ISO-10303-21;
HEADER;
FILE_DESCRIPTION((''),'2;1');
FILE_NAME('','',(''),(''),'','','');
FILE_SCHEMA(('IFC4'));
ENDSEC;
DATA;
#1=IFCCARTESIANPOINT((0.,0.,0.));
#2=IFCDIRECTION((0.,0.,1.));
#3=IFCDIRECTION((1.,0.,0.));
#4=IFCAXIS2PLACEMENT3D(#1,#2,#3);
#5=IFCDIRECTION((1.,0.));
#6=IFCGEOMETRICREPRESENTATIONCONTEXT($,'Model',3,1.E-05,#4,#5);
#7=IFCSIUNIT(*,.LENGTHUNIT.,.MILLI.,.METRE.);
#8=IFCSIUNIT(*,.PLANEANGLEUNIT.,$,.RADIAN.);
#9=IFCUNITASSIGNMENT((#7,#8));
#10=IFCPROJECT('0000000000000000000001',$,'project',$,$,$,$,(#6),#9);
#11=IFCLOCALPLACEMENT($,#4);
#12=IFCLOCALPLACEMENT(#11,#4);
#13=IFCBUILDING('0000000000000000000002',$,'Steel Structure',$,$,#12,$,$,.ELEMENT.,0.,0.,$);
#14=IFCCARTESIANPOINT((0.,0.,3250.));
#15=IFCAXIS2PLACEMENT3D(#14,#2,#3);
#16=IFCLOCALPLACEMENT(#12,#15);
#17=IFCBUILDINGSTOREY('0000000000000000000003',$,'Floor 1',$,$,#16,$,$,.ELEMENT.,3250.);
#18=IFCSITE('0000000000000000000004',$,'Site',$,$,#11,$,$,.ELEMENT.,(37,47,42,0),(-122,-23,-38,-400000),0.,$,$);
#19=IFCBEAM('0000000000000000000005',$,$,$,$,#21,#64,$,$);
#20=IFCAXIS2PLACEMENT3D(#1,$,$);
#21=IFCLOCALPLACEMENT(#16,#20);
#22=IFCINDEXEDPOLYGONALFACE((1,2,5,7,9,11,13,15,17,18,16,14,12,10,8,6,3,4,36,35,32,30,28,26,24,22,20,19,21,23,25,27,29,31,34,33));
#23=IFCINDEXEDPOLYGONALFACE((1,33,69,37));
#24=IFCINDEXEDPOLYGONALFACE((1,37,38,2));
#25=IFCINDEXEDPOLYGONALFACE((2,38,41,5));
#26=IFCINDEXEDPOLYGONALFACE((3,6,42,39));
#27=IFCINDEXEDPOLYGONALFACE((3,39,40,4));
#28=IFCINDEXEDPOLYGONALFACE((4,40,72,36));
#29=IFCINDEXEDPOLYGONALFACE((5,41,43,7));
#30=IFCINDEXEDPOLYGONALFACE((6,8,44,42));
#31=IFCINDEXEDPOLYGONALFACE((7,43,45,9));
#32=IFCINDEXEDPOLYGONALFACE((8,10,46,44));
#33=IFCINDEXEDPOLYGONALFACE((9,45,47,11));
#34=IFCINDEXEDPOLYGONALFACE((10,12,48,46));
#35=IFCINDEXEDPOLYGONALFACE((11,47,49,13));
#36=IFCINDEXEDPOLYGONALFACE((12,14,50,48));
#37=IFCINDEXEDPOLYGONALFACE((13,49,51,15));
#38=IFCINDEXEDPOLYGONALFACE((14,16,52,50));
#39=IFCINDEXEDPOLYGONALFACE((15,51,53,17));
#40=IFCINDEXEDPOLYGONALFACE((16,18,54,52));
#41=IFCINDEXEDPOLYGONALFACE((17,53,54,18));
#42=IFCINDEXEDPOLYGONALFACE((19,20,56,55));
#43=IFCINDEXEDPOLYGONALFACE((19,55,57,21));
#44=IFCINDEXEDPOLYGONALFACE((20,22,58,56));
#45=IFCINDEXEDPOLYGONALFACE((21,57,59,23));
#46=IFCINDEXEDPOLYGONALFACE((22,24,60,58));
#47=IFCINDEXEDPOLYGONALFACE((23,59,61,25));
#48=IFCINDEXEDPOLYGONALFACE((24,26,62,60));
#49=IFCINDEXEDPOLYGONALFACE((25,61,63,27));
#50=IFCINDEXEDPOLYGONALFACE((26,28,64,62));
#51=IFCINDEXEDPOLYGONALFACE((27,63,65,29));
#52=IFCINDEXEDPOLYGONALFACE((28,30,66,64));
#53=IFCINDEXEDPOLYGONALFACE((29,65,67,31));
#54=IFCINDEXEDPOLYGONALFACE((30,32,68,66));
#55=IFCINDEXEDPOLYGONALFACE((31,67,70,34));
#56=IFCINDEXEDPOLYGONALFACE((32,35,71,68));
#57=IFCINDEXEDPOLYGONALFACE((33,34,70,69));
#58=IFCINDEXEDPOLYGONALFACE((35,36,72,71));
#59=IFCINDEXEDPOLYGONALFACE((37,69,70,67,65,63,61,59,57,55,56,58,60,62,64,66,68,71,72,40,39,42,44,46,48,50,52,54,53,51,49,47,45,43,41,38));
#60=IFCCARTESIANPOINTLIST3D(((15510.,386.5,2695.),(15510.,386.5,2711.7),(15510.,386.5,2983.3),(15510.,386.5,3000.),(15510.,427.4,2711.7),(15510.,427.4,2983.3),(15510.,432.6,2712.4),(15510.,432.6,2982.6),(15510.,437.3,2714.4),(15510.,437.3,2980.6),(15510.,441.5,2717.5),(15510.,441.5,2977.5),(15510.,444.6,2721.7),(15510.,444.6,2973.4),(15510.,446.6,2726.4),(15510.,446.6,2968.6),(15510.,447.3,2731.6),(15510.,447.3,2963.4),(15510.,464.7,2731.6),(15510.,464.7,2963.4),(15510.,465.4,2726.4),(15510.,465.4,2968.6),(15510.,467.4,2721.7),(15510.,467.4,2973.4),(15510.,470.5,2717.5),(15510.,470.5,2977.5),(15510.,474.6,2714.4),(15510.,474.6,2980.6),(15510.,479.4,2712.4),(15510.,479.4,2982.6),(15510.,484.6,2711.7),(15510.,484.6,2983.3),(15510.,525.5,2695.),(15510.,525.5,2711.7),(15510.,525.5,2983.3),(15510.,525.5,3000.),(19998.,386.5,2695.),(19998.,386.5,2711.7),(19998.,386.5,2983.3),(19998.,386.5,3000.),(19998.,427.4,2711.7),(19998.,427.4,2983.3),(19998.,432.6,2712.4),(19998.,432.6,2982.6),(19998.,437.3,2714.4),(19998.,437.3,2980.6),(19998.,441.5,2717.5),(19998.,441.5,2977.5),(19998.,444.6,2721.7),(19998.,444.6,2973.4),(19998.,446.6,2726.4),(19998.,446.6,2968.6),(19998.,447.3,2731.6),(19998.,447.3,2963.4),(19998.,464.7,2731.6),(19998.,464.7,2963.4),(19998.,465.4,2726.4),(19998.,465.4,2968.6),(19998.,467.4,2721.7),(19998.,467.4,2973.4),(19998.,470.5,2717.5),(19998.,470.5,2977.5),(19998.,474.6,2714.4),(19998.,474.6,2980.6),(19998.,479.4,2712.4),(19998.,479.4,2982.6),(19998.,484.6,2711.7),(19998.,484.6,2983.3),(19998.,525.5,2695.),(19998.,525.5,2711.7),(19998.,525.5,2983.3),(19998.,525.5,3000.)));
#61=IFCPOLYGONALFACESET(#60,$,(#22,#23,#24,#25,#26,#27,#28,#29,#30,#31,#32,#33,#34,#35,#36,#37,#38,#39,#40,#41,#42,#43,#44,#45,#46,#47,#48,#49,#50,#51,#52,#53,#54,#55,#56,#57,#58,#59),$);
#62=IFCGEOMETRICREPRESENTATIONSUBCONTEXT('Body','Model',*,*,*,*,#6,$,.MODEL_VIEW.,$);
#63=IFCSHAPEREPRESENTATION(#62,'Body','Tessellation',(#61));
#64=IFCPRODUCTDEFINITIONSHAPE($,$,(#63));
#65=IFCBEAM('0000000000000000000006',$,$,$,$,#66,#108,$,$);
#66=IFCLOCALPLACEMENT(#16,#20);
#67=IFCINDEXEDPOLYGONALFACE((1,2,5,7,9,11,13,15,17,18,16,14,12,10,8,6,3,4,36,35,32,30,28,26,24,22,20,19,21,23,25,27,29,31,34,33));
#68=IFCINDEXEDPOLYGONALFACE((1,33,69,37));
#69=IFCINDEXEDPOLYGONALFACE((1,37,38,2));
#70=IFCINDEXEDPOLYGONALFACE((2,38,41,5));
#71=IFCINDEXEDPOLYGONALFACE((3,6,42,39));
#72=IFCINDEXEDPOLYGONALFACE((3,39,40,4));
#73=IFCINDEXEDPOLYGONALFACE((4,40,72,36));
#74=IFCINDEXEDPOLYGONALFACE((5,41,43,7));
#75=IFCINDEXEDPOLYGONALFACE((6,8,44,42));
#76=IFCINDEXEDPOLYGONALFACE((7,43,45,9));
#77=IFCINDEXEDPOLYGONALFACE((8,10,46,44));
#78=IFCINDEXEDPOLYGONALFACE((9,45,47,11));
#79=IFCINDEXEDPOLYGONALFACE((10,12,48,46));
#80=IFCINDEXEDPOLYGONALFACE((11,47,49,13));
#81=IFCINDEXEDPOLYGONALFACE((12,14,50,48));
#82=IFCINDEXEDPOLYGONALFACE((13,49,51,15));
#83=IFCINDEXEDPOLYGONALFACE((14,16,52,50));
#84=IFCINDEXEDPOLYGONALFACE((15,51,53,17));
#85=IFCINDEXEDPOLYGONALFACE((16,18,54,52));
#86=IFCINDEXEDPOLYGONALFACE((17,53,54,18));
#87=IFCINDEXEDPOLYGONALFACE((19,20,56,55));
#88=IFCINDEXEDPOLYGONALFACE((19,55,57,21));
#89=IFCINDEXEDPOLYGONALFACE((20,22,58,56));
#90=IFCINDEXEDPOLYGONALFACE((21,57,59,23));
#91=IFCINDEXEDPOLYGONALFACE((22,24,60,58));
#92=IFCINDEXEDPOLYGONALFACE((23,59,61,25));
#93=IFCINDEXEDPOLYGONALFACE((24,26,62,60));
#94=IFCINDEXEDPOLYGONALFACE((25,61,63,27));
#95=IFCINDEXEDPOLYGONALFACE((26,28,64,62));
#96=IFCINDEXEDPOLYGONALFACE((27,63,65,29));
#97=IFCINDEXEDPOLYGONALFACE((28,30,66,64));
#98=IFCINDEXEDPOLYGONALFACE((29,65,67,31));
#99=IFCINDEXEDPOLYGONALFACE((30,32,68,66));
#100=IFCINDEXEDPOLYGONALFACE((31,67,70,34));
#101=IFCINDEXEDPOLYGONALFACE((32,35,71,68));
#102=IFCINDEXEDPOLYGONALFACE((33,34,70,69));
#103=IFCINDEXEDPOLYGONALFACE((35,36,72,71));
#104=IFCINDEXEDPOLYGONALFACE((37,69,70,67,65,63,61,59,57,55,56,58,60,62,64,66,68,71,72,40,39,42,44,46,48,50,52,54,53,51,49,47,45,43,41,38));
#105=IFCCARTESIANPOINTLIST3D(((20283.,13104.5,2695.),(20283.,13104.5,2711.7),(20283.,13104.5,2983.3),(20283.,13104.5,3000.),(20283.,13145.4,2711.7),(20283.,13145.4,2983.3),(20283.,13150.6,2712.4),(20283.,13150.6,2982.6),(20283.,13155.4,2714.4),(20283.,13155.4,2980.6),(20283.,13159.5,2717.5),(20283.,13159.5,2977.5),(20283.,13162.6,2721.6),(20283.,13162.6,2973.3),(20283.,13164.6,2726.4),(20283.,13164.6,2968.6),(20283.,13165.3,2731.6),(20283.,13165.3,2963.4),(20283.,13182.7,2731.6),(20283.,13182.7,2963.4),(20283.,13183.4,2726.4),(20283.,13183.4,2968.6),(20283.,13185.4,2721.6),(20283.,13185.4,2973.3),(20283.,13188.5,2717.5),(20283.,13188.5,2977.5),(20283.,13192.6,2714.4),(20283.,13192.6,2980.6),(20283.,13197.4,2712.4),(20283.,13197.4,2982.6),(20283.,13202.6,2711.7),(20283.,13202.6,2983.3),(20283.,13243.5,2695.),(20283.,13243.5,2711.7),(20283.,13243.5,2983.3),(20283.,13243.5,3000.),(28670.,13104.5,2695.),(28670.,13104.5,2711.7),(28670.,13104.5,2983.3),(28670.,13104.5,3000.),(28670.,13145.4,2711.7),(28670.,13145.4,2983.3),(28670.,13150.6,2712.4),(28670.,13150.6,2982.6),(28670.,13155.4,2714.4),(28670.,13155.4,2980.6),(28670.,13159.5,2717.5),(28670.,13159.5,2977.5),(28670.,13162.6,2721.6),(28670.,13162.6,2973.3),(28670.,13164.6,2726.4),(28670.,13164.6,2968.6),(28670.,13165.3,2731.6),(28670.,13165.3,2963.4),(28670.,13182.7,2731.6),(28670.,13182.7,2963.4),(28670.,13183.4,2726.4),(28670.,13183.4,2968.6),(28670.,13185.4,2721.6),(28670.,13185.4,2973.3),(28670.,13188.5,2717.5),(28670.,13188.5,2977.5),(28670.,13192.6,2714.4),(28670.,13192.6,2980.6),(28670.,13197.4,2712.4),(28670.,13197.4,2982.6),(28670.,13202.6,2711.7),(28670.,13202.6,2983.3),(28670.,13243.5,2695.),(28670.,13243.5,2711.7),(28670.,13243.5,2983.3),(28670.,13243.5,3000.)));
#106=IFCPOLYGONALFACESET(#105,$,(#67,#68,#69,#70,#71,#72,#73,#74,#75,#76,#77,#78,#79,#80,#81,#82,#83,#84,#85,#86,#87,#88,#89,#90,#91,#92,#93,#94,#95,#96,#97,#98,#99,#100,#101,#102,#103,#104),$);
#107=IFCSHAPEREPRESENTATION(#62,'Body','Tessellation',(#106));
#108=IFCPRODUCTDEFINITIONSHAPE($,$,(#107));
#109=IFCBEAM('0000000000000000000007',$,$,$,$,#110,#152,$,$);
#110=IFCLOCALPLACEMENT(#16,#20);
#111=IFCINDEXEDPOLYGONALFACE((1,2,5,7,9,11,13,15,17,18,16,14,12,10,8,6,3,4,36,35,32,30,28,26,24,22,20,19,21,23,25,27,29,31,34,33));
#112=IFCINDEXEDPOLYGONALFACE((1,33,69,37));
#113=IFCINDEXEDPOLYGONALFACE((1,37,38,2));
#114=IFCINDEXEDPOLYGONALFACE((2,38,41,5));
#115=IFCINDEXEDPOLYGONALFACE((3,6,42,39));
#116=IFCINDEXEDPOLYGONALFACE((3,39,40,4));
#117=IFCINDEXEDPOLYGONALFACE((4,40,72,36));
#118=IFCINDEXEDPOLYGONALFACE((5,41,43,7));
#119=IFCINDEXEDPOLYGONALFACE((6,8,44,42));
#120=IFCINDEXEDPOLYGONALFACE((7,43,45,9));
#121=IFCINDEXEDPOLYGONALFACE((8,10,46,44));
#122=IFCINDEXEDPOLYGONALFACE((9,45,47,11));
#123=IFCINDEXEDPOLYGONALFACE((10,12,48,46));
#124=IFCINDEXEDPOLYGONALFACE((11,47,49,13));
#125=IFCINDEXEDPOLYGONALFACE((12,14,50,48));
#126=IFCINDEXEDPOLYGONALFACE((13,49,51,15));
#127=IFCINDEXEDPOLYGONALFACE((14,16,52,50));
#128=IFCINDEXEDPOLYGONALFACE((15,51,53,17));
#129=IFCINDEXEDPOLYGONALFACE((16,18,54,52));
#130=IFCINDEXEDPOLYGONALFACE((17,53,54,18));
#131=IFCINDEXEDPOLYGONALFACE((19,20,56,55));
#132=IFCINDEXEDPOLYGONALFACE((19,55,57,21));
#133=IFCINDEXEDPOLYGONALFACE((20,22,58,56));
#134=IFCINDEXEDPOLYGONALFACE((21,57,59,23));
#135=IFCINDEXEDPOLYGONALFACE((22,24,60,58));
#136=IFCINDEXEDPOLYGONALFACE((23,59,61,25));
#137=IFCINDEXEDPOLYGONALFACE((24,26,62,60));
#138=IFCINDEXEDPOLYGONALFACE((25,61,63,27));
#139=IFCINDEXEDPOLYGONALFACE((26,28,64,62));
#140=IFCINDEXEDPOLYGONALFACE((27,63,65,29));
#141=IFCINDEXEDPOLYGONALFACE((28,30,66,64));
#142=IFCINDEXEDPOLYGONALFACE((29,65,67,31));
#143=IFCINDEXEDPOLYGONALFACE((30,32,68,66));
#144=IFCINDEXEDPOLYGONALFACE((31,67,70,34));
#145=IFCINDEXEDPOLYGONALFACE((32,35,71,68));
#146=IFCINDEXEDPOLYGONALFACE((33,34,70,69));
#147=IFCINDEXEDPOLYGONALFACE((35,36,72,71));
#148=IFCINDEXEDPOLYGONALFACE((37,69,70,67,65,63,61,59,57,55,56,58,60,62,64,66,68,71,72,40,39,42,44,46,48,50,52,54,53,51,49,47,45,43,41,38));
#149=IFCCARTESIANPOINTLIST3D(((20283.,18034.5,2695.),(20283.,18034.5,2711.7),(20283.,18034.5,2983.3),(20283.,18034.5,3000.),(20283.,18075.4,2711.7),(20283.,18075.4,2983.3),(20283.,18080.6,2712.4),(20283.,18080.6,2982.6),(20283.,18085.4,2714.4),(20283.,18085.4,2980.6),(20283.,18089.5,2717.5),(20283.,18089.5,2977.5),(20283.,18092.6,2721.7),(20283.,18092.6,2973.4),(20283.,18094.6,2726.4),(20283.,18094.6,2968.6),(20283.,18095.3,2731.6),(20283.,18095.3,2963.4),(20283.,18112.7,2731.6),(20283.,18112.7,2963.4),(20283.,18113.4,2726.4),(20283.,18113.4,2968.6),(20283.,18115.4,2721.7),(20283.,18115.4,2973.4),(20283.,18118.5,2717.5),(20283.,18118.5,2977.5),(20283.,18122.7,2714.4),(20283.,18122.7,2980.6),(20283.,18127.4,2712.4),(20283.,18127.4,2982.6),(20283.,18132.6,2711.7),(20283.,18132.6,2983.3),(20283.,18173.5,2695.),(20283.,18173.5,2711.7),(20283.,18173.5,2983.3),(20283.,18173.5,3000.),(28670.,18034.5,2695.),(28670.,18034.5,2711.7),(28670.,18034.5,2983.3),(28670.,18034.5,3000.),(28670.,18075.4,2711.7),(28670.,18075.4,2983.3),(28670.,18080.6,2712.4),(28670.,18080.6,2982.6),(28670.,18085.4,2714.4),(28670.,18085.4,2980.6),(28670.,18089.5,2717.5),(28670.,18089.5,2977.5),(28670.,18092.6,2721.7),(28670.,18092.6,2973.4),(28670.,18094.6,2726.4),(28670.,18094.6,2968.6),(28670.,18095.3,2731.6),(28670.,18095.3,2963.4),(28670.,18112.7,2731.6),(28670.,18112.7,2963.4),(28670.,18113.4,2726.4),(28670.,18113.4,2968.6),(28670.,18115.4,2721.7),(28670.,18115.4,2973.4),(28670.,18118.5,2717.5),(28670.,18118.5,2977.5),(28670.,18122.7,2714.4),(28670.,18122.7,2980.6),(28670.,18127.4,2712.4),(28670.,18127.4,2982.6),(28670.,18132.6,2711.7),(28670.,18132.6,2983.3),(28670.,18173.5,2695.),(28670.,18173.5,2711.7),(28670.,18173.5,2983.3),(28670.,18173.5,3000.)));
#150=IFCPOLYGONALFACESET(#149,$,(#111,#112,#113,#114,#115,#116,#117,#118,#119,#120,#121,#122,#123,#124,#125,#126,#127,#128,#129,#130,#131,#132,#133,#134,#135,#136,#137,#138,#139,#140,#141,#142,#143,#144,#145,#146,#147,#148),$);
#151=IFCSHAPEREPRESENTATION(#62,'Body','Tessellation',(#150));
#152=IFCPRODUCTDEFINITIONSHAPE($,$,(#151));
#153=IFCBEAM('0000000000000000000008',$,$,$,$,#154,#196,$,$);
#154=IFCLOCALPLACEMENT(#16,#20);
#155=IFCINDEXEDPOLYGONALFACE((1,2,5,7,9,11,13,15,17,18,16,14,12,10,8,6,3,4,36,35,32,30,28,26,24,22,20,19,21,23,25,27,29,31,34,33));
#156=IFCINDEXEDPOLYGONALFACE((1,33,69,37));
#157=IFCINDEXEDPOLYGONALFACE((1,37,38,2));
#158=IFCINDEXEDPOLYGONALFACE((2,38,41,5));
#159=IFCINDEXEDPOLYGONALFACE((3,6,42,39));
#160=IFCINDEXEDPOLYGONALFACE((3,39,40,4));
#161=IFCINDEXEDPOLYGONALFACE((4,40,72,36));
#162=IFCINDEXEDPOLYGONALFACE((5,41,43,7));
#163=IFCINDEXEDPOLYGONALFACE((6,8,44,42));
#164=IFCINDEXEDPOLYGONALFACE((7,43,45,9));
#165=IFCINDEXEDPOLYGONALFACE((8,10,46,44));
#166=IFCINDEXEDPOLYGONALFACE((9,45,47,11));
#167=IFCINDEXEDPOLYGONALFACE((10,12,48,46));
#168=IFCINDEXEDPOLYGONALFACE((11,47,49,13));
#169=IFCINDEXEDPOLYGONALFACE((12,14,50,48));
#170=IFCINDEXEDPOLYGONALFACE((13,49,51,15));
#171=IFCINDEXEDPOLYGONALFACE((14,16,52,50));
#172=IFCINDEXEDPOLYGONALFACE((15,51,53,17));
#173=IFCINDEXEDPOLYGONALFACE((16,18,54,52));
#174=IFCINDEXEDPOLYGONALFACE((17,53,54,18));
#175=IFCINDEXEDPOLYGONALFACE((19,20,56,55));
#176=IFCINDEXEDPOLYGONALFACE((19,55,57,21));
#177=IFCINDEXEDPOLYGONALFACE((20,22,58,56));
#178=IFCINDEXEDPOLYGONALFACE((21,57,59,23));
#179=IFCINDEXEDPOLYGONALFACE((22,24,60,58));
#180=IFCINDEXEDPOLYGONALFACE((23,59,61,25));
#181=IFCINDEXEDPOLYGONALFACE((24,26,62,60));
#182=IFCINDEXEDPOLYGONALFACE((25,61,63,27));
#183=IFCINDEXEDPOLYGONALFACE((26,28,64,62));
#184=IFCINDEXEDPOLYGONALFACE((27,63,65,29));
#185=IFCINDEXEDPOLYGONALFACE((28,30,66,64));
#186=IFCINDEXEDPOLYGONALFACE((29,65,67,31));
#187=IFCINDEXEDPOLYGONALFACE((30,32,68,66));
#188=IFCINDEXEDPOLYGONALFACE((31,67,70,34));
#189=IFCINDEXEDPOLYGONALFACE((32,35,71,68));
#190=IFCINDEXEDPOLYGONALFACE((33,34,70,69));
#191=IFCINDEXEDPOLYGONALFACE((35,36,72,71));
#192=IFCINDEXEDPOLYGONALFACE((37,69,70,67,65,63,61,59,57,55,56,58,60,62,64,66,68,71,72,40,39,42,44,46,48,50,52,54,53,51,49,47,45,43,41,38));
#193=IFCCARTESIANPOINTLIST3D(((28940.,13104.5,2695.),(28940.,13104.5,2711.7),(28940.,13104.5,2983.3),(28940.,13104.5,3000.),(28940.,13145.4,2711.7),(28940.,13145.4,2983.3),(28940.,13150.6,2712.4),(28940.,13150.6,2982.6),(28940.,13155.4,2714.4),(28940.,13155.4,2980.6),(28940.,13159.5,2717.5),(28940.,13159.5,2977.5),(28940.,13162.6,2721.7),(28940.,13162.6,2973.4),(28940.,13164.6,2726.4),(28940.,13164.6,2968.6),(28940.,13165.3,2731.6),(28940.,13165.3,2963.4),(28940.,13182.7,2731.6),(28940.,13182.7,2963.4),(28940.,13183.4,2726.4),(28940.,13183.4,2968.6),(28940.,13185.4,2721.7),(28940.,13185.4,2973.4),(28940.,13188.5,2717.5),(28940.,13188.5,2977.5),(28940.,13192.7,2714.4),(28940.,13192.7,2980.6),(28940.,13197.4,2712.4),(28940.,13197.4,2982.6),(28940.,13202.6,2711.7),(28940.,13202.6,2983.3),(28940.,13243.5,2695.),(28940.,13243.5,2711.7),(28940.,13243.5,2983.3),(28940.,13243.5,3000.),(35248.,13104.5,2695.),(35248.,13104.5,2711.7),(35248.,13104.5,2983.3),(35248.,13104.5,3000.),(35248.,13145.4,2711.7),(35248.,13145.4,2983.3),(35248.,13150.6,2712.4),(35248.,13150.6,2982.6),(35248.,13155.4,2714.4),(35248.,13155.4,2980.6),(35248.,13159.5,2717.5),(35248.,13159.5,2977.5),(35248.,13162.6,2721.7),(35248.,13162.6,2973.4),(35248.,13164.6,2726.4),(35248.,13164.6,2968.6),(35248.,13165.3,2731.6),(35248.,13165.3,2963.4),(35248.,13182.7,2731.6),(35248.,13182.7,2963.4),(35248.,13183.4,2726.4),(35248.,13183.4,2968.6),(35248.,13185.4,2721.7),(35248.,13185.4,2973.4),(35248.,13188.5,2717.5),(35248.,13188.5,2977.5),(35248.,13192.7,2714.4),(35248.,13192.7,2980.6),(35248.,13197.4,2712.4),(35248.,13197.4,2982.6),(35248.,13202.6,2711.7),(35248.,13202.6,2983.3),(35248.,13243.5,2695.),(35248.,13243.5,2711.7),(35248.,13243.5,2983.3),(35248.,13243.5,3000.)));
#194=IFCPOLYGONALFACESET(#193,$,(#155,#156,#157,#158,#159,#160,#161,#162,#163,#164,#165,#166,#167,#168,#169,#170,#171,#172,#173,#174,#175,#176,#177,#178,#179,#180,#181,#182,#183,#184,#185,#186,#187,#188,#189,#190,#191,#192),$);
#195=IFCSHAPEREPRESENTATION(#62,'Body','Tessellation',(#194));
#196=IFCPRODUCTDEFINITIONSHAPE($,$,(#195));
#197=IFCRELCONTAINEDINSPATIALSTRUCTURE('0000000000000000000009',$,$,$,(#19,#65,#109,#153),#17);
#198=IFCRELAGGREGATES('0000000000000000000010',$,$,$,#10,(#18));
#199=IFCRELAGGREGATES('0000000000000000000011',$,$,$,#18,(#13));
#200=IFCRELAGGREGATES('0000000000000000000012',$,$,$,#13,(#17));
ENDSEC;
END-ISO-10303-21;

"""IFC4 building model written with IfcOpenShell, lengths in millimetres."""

from ifc_helpers import new_model, si_unit, direction, frame, origin_with_axes, origin_2d_with_axis, place, context, subcontext, project, spatial, i_section, extrude, element, save


model = new_model("IFC4")

# Units and contexts
model_context = context("Model", 3, precision=1e-05, world=origin_with_axes(), true_north=direction((1.0, 0.0)))
body_context = subcontext(model_context, "Body", "Model", "MODEL_VIEW")
ifc_project = project(units=[si_unit("LENGTHUNIT", "METRE", prefix="MILLI"), si_unit("PLANEANGLEUNIT", "RADIAN")], contexts=[model_context])

# Site, building, storey
site_placement = place(None, origin_with_axes())
site = spatial("IfcSite", under=ifc_project, at=site_placement, Name="Site", CompositionType="ELEMENT", RefLatitude=(37, 47, 42, 0), RefLongitude=(-122, -23, -38, -400000), RefElevation=0.0)
building_placement = place(site_placement, origin_with_axes())
building = spatial("IfcBuilding", under=site, at=building_placement, Name="Steel Structure", CompositionType="ELEMENT", ElevationOfRefHeight=0.0, ElevationOfTerrain=0.0)
storey_placement = place(building_placement, frame((0.0, 0.0, 3250.0), z_axis=(0.0, 0.0, 1.0), x_axis=(1.0, 0.0, 0.0)))
storey = spatial("IfcBuildingStorey", under=building, at=storey_placement, Name="Floor 1", CompositionType="ELEMENT", Elevation=3250.0)

# Beams
beam_1_placement = place(storey_placement, frame((15510.0, 456.0, 2695.0), z_axis=(1.0, 0.0, 0.0), x_axis=(0.0, 1.0, 0.0)))
element("IfcBeam", 1, at=beam_1_placement, inside=storey, context=body_context, shape_type="SweptSolid", body=[
    extrude(i_section(OverallWidth=139.0, OverallDepth=305.0, WebThickness=17.4, FlangeThickness=16.7, FilletRadius=19.9, at=origin_2d_with_axis()), frame((0.0, 152.5, 0.0), z_axis=(0.0, 0.0, 1.0), x_axis=(1.0, 0.0, 0.0)), (0.0, 0.0, 1.0), 4488.0),
])
for number, where, z_axis, x_axis in (
    (2, (20283.0, 13174.0, 2695.0), (1.0, 0.0, 0.0), (0.0, 1.0, 0.0)),
    (3, (28670.0, 18104.0, 2695.0), (-1.0, 0.0, 0.0), (0.0, -1.0, 0.0)),
):
    element("IfcBeam", number, at=place(storey_placement, frame(where, z_axis=z_axis, x_axis=x_axis)), inside=storey, context=body_context, shape_type="SweptSolid", body=[
        extrude(i_section(OverallWidth=139.0, OverallDepth=305.0, WebThickness=17.4, FlangeThickness=16.7, FilletRadius=19.9, at=origin_2d_with_axis()), frame((0.0, 152.5, 0.0), z_axis=(0.0, 0.0, 1.0), x_axis=(1.0, 0.0, 0.0)), (0.0, 0.0, 1.0), 8387.0),
    ])
for number, where, z_axis, x_axis in (
    (4, (28940.0, 13174.0, 2695.0), (1.0, 0.0, 0.0), (0.0, 1.0, 0.0)),
):
    element("IfcBeam", number, at=place(storey_placement, frame(where, z_axis=z_axis, x_axis=x_axis)), inside=storey, context=body_context, shape_type="SweptSolid", body=[
        extrude(i_section(OverallWidth=139.0, OverallDepth=305.0, WebThickness=17.4, FlangeThickness=16.7, FilletRadius=19.9, at=origin_2d_with_axis()), frame((0.0, 152.5, 0.0), z_axis=(0.0, 0.0, 1.0), x_axis=(1.0, 0.0, 0.0)), (0.0, 0.0, 1.0), 6308.0),
    ])

save(model, "model.ifc")
